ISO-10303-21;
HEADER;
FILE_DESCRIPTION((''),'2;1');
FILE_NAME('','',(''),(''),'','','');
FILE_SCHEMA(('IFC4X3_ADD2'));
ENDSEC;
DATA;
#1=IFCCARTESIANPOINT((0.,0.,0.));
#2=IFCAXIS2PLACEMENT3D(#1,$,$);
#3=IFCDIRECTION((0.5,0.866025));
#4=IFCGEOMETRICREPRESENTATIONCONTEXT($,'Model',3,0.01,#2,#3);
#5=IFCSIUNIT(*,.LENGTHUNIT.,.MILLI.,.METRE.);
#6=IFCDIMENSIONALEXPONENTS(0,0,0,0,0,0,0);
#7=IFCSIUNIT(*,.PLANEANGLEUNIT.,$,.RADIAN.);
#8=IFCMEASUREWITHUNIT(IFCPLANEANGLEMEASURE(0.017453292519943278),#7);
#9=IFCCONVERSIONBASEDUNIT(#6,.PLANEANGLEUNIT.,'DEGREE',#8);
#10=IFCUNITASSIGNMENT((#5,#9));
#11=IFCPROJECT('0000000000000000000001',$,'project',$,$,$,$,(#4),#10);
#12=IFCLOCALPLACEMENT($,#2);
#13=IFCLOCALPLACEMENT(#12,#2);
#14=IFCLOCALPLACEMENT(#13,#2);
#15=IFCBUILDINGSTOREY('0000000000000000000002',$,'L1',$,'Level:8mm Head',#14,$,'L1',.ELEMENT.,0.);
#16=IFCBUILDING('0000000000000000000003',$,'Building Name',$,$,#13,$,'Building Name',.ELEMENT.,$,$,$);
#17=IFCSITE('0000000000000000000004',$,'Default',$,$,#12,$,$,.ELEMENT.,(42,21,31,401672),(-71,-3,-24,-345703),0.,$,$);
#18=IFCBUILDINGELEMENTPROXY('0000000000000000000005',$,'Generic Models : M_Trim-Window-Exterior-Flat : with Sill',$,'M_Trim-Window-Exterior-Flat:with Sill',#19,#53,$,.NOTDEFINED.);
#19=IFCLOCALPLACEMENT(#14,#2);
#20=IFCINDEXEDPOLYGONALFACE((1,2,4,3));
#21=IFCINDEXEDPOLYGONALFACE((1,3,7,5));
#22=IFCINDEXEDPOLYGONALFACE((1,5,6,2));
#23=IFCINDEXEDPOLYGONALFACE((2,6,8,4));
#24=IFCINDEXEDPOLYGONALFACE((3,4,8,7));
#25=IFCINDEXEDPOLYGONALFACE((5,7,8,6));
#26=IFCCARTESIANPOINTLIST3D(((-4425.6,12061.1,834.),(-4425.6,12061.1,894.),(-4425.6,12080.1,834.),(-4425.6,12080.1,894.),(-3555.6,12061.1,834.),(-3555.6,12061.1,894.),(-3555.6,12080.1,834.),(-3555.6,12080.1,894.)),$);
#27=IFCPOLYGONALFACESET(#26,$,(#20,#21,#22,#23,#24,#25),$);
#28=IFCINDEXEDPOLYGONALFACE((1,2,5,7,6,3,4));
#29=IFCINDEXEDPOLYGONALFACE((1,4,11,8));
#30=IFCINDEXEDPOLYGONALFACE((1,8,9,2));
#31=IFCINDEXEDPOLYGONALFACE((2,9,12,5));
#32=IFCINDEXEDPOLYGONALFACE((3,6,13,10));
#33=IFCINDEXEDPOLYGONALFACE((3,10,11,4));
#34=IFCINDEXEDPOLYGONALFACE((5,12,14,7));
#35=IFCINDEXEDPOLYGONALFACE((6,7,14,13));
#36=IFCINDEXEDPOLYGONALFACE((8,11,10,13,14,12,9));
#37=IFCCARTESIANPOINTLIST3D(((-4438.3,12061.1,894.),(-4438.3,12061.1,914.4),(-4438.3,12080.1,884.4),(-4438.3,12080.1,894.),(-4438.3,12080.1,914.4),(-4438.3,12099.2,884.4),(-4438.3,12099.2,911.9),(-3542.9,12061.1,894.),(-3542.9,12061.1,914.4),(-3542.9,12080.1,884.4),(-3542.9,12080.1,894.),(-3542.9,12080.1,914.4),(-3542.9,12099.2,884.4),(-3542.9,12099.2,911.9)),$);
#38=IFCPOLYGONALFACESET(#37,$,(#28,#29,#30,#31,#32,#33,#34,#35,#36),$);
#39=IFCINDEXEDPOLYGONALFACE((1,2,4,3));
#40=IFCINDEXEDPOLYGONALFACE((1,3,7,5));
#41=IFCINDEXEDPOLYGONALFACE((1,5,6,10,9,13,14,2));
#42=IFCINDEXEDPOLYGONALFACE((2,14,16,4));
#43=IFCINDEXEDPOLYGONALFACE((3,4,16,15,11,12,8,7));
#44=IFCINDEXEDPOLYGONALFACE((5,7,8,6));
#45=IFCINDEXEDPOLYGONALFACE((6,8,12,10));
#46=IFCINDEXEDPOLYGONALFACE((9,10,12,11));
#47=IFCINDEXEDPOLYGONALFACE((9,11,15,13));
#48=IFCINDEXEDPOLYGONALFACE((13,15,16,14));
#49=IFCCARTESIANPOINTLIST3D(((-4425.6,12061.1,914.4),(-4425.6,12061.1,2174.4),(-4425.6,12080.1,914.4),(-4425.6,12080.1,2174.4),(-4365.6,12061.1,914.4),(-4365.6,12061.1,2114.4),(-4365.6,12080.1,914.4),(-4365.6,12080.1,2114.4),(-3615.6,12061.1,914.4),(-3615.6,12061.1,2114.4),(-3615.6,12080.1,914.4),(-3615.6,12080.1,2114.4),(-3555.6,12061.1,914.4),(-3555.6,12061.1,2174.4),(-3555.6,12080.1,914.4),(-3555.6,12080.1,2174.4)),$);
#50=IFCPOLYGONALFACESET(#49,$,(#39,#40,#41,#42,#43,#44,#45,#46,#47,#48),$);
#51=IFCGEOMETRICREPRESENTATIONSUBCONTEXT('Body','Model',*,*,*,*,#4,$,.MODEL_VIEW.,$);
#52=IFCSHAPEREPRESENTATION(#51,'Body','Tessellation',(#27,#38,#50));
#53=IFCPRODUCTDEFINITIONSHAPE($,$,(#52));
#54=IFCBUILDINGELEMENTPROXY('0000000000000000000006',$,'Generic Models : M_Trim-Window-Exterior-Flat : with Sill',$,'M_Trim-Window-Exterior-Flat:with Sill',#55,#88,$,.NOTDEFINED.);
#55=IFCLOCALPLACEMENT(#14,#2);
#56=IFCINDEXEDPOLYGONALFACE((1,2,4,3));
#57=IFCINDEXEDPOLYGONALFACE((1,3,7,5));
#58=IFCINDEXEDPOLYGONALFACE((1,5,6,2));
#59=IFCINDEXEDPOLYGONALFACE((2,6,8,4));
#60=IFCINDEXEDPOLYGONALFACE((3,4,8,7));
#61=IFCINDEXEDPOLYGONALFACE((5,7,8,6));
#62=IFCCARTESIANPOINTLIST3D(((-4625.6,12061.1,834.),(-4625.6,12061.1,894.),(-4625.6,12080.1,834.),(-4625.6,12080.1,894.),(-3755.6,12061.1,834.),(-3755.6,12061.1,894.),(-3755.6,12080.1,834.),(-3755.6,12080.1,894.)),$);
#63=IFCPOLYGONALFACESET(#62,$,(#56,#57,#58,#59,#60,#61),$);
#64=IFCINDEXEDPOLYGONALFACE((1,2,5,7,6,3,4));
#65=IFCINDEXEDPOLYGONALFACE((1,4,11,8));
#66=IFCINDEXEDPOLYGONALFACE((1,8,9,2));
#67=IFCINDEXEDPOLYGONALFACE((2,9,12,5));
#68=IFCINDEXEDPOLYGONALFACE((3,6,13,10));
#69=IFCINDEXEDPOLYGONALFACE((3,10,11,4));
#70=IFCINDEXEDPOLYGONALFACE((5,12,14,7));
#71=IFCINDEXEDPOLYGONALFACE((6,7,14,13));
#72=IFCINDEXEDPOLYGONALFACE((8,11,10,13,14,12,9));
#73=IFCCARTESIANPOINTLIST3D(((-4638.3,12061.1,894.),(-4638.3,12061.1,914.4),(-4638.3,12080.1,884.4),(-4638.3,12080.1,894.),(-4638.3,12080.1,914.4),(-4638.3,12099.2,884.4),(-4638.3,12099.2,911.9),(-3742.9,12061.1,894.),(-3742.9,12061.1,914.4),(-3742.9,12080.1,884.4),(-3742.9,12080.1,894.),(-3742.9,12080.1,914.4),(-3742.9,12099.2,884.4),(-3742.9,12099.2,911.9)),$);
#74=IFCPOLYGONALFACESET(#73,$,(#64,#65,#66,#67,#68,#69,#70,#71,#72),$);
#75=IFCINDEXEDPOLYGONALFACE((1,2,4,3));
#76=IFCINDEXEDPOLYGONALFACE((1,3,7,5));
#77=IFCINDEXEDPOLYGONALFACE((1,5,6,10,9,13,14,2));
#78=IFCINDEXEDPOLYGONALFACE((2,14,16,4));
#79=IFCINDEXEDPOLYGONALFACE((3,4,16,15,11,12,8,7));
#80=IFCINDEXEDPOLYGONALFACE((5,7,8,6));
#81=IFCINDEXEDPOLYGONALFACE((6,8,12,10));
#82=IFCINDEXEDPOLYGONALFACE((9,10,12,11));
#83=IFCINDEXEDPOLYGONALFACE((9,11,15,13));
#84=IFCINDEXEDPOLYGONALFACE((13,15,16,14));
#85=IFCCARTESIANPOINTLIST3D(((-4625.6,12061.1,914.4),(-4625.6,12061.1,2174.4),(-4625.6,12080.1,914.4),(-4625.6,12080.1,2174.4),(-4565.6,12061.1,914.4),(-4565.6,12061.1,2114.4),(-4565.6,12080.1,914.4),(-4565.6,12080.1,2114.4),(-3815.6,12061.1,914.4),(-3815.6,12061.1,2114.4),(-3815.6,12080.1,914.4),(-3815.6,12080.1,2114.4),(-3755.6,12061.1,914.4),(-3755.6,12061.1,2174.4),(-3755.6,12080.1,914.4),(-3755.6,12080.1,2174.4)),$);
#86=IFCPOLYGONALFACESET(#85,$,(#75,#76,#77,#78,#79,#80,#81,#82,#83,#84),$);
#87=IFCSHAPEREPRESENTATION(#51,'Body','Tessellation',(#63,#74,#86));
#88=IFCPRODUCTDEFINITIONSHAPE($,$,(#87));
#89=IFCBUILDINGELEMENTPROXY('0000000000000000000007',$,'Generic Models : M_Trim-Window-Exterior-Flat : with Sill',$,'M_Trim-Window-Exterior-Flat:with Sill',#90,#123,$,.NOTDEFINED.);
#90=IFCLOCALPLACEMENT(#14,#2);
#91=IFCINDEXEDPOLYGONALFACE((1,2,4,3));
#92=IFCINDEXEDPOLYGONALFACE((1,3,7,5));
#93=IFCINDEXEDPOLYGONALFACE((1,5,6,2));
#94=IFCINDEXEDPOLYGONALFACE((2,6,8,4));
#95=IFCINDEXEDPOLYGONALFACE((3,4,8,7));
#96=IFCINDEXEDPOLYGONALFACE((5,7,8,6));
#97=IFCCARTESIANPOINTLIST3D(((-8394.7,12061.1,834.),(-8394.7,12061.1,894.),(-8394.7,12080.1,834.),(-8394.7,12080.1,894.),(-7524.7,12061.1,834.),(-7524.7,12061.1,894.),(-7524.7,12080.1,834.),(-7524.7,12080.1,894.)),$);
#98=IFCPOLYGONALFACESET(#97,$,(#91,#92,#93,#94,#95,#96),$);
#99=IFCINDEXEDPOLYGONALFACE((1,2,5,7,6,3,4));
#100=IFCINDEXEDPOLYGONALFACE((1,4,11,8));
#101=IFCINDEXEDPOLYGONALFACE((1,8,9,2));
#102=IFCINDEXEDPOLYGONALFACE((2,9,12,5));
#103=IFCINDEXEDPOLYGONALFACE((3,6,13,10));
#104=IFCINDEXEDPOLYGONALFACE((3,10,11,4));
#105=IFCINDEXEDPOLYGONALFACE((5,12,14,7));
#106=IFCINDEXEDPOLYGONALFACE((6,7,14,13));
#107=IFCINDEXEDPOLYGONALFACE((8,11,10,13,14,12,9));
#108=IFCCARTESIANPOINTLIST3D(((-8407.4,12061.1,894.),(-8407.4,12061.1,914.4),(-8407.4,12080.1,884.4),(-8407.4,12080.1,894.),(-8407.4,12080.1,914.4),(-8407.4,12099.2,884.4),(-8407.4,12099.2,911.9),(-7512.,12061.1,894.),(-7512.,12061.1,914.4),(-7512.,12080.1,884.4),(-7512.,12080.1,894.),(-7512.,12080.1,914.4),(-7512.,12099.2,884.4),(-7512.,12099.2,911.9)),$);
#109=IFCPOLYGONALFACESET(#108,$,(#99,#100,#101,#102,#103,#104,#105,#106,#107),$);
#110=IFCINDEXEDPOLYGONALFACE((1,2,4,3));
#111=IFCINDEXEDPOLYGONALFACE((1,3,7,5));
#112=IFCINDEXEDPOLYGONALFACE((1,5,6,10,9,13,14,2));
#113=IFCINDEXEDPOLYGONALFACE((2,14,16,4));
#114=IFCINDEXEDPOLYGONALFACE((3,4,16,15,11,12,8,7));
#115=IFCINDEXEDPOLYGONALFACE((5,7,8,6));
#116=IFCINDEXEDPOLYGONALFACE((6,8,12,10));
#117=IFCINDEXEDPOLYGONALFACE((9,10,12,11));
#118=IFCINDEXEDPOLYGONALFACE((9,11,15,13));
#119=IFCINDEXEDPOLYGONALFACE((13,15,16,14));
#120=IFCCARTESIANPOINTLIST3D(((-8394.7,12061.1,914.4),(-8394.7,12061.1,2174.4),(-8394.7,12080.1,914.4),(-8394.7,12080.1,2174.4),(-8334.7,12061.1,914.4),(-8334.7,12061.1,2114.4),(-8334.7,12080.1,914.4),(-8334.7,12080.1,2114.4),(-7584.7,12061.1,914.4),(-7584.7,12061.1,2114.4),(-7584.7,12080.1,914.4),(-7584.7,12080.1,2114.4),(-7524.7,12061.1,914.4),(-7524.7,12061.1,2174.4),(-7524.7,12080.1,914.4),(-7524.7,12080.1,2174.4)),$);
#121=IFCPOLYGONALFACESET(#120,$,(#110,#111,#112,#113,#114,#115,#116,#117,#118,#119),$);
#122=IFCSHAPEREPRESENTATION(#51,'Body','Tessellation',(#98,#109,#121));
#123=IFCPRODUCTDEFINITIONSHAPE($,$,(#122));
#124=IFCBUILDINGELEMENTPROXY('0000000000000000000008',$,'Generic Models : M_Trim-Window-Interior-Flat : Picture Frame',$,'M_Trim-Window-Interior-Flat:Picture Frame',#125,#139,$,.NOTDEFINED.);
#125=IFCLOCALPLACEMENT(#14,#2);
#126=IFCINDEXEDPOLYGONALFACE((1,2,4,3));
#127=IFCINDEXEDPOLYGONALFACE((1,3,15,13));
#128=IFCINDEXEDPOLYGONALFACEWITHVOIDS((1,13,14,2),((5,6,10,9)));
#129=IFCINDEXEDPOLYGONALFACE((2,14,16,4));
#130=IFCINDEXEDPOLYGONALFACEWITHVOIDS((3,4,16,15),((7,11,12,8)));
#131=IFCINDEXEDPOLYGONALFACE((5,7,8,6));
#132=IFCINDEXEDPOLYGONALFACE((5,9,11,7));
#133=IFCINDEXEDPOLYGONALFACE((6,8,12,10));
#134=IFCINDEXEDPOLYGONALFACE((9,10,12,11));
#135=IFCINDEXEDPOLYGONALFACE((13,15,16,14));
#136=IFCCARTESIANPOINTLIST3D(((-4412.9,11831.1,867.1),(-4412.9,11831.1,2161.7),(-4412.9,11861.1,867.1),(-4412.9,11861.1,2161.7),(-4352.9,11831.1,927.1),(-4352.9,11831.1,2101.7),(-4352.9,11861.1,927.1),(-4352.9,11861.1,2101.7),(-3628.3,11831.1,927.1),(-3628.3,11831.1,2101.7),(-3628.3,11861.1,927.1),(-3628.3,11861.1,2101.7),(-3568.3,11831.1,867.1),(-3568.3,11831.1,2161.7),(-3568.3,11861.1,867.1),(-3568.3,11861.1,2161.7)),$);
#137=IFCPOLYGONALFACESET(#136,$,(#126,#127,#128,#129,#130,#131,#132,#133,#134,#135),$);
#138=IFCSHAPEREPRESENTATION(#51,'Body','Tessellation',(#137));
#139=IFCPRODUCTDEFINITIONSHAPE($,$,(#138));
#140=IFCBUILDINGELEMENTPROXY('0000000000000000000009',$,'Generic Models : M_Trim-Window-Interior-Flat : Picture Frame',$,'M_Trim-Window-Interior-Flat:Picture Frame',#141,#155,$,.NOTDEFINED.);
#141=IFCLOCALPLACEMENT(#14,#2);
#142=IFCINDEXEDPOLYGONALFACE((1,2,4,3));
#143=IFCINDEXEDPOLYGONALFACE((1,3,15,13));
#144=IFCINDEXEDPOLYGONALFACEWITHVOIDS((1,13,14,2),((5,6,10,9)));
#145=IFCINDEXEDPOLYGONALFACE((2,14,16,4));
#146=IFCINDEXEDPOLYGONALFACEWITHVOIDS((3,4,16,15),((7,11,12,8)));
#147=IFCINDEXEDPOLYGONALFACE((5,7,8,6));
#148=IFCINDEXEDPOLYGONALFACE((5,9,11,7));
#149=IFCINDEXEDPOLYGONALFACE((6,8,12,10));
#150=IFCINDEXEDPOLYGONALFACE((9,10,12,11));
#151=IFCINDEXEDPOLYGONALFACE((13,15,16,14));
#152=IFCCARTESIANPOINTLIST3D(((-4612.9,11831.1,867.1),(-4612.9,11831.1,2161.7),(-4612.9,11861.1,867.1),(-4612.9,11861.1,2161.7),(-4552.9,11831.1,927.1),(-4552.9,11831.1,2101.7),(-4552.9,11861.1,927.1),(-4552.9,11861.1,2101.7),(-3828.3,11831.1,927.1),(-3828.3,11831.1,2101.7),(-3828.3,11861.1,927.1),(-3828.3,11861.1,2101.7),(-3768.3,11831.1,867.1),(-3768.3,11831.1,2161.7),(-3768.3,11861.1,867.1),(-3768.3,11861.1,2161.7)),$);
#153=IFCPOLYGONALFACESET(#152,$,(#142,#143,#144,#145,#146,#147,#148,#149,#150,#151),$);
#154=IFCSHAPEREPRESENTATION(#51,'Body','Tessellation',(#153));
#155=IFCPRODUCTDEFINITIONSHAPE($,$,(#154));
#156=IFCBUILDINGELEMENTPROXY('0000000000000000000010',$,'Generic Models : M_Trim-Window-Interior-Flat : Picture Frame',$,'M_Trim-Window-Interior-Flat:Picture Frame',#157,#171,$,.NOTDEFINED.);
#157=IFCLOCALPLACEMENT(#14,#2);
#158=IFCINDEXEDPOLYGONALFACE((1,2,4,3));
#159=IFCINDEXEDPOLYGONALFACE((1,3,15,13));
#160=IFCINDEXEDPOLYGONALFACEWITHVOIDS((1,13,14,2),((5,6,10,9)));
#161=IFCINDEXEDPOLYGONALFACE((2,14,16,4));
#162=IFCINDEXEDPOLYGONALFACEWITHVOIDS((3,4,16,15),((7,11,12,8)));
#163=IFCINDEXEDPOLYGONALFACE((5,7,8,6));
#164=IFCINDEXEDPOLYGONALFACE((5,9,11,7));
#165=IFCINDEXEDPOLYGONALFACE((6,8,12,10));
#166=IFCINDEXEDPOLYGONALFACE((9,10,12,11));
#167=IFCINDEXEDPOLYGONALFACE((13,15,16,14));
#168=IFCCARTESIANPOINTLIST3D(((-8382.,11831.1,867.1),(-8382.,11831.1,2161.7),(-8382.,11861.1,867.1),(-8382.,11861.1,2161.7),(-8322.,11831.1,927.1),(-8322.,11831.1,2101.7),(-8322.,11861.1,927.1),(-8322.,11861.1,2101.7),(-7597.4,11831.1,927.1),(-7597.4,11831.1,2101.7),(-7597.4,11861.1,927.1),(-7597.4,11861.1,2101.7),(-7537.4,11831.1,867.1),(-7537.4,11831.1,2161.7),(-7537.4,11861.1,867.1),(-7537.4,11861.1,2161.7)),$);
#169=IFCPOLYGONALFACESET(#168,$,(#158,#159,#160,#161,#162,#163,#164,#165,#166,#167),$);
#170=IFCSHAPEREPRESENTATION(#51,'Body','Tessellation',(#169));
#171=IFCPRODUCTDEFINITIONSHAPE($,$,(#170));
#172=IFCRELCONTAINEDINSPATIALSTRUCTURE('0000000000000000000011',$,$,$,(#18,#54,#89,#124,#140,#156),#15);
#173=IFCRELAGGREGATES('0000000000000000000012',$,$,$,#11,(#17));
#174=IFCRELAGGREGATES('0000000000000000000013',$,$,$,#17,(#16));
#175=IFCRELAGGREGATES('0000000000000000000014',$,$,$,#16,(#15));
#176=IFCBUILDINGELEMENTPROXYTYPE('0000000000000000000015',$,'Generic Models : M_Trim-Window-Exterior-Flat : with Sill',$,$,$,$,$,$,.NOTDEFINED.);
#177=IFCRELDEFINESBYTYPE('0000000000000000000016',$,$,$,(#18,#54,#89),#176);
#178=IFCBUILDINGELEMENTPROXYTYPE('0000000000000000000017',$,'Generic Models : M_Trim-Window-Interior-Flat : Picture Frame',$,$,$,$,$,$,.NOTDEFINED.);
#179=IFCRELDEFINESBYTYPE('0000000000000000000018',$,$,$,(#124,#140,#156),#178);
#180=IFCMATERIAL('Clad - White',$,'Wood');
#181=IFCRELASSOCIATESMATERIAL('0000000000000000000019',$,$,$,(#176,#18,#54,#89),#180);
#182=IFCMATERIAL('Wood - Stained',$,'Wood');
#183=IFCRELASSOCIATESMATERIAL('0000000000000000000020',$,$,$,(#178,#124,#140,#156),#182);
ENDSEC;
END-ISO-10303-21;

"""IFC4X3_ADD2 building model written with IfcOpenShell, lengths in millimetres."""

from ifc_helpers import new_model, entity, si_unit, converted_unit, direction, frame, frame_2d, origin, place, context, subcontext, project, spatial, polyline, rectangle, outline, extrude, source, transform, mapped, material, type_object, type_shapes, element, save


model = new_model("IFC4X3_ADD2")

# Units and contexts
model_context = context("Model", 3, precision=0.01, world=origin(), true_north=direction((0.5, 0.866025)))
body_context = subcontext(model_context, "Body", "Model", "MODEL_VIEW")
ifc_project = project(units=[si_unit("LENGTHUNIT", "METRE", prefix="MILLI"), converted_unit("PLANEANGLEUNIT", "DEGREE", entity("IfcPlaneAngleMeasure", 0.017453292519943278), si_unit("PLANEANGLEUNIT", "RADIAN"), dimensions=[0, 0, 0, 0, 0, 0, 0])], contexts=[model_context])

# Site, building, storey
site_placement = place(None, origin())
site = spatial("IfcSite", under=ifc_project, at=site_placement, Name="Default", CompositionType="ELEMENT", RefLatitude=(42, 21, 31, 401672), RefLongitude=(-71, -3, -24, -345703), RefElevation=0.0)
building_placement = place(site_placement, origin())
building = spatial("IfcBuilding", under=site, at=building_placement, Name="Building Name", LongName="Building Name", CompositionType="ELEMENT")
storey_placement = place(building_placement, origin())
storey = spatial("IfcBuildingStorey", under=building, at=storey_placement, Name="L1", ObjectType="Level:8mm Head", LongName="L1", CompositionType="ELEMENT", Elevation=0.0)

# Shared definitions
ifc_material_1 = material(Name="Wood - Stained", Category="Wood")

# Building element proxies
ifc_material_2 = material(Name="Clad - White", Category="Wood")
building_element_proxy_type_1 = type_object("IfcBuildingElementProxyType", Name="Generic Models : M_Trim-Window-Exterior-Flat : with Sill", PredefinedType="NOTDEFINED", material=ifc_material_2)
shared_shape_1 = source(origin(), body_context, "Body", "SweptSolid", [
    extrude(rectangle(XDim=870.0, YDim=60.0, at=frame_2d((0.0, 0.0), x_axis=(1.0, 0.0))), frame((0.0, -1250.4, 0.0), z_axis=(0.0, 0.0, 1.0), x_axis=(-1.0, 0.0, 0.0)), (0.0, 0.0, 1.0), 19.0),
    extrude(outline(polyline([(-19.0, -15.2), (0.0, -15.2), (0.0, -5.7), (19.0, -5.7), (19.0, 14.8), (0.0, 14.8), (-19.0, 12.3), (-19.0, -15.2)])), frame((-447.7, -1214.8, 19.0), z_axis=(1.0, 0.0, 0.0), x_axis=(0.0, 0.0, -1.0)), (0.0, 0.0, 1.0), 895.4),
    extrude(outline(polyline([(-645.0, -435.0), (615.0, -435.0), (615.0, -375.0), (-585.0, -375.0), (-585.0, 375.0), (615.0, 375.0), (615.0, 435.0), (-645.0, 435.0), (-645.0, -435.0)])), frame((0.0, -585.0, 0.0), z_axis=(0.0, 0.0, 1.0), x_axis=(0.0, -1.0, 0.0)), (0.0, 0.0, 1.0), 19.0),
])
type_shapes(building_element_proxy_type_1, [shared_shape_1])
for number, where, z_axis, x_axis, name in (
    (1, (-3990.6, 12061.1, 2114.4), (0.0, 1.0, 0.0), (-1.0, 0.0, 0.0), "Generic Models : M_Trim-Window-Exterior-Flat : with Sill"),
    (2, (-4190.6, 12061.1, 2114.4), (0.0, 1.0, 0.0), (-1.0, 0.0, 0.0), "Generic Models : M_Trim-Window-Exterior-Flat : with Sill"),
    (3, (-7959.7, 12061.1, 2114.4), (0.0, 1.0, 0.0), (-1.0, 0.0, 0.0), "Generic Models : M_Trim-Window-Exterior-Flat : with Sill"),
):
    element("IfcBuildingElementProxy", number, at=place(storey_placement, frame(where, z_axis=z_axis, x_axis=x_axis)), inside=storey, type_object=building_element_proxy_type_1, material=ifc_material_2, Name=name, ObjectType="M_Trim-Window-Exterior-Flat:with Sill", PredefinedType="NOTDEFINED", context=body_context, shape_type="MappedRepresentation", body=[
        mapped(shared_shape_1, transform((0.0, 0.0, 0.0), scale=1.0)),
    ])
building_element_proxy_type_2 = type_object("IfcBuildingElementProxyType", Name="Generic Models : M_Trim-Window-Interior-Flat : Picture Frame", PredefinedType="NOTDEFINED", material=ifc_material_1)
shared_shape_2 = source(origin(), body_context, "Body", "SweptSolid", [
    extrude(outline(polyline([(-422.3, -647.3), (422.3, -647.3), (422.3, 647.3), (-422.3, 647.3), (-422.3, -647.3)]), holes=[polyline([(-362.3, -587.3), (-362.3, 587.3), (362.3, 587.3), (362.3, -587.3), (-362.3, -587.3)])]), frame((0.0, -600.0, 0.0), z_axis=(0.0, 0.0, 1.0), x_axis=(-1.0, 0.0, 0.0)), (0.0, 0.0, 1.0), 30.0),
])
type_shapes(building_element_proxy_type_2, [shared_shape_2])
for number, where, z_axis, x_axis, name in (
    (4, (-3990.6, 11861.1, 2114.4), (0.0, -1.0, 0.0), (1.0, 0.0, 0.0), "Generic Models : M_Trim-Window-Interior-Flat : Picture Frame"),
    (5, (-4190.6, 11861.1, 2114.4), (0.0, -1.0, 0.0), (1.0, 0.0, 0.0), "Generic Models : M_Trim-Window-Interior-Flat : Picture Frame"),
    (6, (-7959.7, 11861.1, 2114.4), (0.0, -1.0, 0.0), (1.0, 0.0, 0.0), "Generic Models : M_Trim-Window-Interior-Flat : Picture Frame"),
):
    element("IfcBuildingElementProxy", number, at=place(storey_placement, frame(where, z_axis=z_axis, x_axis=x_axis)), inside=storey, type_object=building_element_proxy_type_2, material=ifc_material_1, Name=name, ObjectType="M_Trim-Window-Interior-Flat:Picture Frame", PredefinedType="NOTDEFINED", context=body_context, shape_type="MappedRepresentation", body=[
        mapped(shared_shape_2, transform((0.0, 0.0, 0.0), scale=1.0)),
    ])

save(model, "model.ifc")
